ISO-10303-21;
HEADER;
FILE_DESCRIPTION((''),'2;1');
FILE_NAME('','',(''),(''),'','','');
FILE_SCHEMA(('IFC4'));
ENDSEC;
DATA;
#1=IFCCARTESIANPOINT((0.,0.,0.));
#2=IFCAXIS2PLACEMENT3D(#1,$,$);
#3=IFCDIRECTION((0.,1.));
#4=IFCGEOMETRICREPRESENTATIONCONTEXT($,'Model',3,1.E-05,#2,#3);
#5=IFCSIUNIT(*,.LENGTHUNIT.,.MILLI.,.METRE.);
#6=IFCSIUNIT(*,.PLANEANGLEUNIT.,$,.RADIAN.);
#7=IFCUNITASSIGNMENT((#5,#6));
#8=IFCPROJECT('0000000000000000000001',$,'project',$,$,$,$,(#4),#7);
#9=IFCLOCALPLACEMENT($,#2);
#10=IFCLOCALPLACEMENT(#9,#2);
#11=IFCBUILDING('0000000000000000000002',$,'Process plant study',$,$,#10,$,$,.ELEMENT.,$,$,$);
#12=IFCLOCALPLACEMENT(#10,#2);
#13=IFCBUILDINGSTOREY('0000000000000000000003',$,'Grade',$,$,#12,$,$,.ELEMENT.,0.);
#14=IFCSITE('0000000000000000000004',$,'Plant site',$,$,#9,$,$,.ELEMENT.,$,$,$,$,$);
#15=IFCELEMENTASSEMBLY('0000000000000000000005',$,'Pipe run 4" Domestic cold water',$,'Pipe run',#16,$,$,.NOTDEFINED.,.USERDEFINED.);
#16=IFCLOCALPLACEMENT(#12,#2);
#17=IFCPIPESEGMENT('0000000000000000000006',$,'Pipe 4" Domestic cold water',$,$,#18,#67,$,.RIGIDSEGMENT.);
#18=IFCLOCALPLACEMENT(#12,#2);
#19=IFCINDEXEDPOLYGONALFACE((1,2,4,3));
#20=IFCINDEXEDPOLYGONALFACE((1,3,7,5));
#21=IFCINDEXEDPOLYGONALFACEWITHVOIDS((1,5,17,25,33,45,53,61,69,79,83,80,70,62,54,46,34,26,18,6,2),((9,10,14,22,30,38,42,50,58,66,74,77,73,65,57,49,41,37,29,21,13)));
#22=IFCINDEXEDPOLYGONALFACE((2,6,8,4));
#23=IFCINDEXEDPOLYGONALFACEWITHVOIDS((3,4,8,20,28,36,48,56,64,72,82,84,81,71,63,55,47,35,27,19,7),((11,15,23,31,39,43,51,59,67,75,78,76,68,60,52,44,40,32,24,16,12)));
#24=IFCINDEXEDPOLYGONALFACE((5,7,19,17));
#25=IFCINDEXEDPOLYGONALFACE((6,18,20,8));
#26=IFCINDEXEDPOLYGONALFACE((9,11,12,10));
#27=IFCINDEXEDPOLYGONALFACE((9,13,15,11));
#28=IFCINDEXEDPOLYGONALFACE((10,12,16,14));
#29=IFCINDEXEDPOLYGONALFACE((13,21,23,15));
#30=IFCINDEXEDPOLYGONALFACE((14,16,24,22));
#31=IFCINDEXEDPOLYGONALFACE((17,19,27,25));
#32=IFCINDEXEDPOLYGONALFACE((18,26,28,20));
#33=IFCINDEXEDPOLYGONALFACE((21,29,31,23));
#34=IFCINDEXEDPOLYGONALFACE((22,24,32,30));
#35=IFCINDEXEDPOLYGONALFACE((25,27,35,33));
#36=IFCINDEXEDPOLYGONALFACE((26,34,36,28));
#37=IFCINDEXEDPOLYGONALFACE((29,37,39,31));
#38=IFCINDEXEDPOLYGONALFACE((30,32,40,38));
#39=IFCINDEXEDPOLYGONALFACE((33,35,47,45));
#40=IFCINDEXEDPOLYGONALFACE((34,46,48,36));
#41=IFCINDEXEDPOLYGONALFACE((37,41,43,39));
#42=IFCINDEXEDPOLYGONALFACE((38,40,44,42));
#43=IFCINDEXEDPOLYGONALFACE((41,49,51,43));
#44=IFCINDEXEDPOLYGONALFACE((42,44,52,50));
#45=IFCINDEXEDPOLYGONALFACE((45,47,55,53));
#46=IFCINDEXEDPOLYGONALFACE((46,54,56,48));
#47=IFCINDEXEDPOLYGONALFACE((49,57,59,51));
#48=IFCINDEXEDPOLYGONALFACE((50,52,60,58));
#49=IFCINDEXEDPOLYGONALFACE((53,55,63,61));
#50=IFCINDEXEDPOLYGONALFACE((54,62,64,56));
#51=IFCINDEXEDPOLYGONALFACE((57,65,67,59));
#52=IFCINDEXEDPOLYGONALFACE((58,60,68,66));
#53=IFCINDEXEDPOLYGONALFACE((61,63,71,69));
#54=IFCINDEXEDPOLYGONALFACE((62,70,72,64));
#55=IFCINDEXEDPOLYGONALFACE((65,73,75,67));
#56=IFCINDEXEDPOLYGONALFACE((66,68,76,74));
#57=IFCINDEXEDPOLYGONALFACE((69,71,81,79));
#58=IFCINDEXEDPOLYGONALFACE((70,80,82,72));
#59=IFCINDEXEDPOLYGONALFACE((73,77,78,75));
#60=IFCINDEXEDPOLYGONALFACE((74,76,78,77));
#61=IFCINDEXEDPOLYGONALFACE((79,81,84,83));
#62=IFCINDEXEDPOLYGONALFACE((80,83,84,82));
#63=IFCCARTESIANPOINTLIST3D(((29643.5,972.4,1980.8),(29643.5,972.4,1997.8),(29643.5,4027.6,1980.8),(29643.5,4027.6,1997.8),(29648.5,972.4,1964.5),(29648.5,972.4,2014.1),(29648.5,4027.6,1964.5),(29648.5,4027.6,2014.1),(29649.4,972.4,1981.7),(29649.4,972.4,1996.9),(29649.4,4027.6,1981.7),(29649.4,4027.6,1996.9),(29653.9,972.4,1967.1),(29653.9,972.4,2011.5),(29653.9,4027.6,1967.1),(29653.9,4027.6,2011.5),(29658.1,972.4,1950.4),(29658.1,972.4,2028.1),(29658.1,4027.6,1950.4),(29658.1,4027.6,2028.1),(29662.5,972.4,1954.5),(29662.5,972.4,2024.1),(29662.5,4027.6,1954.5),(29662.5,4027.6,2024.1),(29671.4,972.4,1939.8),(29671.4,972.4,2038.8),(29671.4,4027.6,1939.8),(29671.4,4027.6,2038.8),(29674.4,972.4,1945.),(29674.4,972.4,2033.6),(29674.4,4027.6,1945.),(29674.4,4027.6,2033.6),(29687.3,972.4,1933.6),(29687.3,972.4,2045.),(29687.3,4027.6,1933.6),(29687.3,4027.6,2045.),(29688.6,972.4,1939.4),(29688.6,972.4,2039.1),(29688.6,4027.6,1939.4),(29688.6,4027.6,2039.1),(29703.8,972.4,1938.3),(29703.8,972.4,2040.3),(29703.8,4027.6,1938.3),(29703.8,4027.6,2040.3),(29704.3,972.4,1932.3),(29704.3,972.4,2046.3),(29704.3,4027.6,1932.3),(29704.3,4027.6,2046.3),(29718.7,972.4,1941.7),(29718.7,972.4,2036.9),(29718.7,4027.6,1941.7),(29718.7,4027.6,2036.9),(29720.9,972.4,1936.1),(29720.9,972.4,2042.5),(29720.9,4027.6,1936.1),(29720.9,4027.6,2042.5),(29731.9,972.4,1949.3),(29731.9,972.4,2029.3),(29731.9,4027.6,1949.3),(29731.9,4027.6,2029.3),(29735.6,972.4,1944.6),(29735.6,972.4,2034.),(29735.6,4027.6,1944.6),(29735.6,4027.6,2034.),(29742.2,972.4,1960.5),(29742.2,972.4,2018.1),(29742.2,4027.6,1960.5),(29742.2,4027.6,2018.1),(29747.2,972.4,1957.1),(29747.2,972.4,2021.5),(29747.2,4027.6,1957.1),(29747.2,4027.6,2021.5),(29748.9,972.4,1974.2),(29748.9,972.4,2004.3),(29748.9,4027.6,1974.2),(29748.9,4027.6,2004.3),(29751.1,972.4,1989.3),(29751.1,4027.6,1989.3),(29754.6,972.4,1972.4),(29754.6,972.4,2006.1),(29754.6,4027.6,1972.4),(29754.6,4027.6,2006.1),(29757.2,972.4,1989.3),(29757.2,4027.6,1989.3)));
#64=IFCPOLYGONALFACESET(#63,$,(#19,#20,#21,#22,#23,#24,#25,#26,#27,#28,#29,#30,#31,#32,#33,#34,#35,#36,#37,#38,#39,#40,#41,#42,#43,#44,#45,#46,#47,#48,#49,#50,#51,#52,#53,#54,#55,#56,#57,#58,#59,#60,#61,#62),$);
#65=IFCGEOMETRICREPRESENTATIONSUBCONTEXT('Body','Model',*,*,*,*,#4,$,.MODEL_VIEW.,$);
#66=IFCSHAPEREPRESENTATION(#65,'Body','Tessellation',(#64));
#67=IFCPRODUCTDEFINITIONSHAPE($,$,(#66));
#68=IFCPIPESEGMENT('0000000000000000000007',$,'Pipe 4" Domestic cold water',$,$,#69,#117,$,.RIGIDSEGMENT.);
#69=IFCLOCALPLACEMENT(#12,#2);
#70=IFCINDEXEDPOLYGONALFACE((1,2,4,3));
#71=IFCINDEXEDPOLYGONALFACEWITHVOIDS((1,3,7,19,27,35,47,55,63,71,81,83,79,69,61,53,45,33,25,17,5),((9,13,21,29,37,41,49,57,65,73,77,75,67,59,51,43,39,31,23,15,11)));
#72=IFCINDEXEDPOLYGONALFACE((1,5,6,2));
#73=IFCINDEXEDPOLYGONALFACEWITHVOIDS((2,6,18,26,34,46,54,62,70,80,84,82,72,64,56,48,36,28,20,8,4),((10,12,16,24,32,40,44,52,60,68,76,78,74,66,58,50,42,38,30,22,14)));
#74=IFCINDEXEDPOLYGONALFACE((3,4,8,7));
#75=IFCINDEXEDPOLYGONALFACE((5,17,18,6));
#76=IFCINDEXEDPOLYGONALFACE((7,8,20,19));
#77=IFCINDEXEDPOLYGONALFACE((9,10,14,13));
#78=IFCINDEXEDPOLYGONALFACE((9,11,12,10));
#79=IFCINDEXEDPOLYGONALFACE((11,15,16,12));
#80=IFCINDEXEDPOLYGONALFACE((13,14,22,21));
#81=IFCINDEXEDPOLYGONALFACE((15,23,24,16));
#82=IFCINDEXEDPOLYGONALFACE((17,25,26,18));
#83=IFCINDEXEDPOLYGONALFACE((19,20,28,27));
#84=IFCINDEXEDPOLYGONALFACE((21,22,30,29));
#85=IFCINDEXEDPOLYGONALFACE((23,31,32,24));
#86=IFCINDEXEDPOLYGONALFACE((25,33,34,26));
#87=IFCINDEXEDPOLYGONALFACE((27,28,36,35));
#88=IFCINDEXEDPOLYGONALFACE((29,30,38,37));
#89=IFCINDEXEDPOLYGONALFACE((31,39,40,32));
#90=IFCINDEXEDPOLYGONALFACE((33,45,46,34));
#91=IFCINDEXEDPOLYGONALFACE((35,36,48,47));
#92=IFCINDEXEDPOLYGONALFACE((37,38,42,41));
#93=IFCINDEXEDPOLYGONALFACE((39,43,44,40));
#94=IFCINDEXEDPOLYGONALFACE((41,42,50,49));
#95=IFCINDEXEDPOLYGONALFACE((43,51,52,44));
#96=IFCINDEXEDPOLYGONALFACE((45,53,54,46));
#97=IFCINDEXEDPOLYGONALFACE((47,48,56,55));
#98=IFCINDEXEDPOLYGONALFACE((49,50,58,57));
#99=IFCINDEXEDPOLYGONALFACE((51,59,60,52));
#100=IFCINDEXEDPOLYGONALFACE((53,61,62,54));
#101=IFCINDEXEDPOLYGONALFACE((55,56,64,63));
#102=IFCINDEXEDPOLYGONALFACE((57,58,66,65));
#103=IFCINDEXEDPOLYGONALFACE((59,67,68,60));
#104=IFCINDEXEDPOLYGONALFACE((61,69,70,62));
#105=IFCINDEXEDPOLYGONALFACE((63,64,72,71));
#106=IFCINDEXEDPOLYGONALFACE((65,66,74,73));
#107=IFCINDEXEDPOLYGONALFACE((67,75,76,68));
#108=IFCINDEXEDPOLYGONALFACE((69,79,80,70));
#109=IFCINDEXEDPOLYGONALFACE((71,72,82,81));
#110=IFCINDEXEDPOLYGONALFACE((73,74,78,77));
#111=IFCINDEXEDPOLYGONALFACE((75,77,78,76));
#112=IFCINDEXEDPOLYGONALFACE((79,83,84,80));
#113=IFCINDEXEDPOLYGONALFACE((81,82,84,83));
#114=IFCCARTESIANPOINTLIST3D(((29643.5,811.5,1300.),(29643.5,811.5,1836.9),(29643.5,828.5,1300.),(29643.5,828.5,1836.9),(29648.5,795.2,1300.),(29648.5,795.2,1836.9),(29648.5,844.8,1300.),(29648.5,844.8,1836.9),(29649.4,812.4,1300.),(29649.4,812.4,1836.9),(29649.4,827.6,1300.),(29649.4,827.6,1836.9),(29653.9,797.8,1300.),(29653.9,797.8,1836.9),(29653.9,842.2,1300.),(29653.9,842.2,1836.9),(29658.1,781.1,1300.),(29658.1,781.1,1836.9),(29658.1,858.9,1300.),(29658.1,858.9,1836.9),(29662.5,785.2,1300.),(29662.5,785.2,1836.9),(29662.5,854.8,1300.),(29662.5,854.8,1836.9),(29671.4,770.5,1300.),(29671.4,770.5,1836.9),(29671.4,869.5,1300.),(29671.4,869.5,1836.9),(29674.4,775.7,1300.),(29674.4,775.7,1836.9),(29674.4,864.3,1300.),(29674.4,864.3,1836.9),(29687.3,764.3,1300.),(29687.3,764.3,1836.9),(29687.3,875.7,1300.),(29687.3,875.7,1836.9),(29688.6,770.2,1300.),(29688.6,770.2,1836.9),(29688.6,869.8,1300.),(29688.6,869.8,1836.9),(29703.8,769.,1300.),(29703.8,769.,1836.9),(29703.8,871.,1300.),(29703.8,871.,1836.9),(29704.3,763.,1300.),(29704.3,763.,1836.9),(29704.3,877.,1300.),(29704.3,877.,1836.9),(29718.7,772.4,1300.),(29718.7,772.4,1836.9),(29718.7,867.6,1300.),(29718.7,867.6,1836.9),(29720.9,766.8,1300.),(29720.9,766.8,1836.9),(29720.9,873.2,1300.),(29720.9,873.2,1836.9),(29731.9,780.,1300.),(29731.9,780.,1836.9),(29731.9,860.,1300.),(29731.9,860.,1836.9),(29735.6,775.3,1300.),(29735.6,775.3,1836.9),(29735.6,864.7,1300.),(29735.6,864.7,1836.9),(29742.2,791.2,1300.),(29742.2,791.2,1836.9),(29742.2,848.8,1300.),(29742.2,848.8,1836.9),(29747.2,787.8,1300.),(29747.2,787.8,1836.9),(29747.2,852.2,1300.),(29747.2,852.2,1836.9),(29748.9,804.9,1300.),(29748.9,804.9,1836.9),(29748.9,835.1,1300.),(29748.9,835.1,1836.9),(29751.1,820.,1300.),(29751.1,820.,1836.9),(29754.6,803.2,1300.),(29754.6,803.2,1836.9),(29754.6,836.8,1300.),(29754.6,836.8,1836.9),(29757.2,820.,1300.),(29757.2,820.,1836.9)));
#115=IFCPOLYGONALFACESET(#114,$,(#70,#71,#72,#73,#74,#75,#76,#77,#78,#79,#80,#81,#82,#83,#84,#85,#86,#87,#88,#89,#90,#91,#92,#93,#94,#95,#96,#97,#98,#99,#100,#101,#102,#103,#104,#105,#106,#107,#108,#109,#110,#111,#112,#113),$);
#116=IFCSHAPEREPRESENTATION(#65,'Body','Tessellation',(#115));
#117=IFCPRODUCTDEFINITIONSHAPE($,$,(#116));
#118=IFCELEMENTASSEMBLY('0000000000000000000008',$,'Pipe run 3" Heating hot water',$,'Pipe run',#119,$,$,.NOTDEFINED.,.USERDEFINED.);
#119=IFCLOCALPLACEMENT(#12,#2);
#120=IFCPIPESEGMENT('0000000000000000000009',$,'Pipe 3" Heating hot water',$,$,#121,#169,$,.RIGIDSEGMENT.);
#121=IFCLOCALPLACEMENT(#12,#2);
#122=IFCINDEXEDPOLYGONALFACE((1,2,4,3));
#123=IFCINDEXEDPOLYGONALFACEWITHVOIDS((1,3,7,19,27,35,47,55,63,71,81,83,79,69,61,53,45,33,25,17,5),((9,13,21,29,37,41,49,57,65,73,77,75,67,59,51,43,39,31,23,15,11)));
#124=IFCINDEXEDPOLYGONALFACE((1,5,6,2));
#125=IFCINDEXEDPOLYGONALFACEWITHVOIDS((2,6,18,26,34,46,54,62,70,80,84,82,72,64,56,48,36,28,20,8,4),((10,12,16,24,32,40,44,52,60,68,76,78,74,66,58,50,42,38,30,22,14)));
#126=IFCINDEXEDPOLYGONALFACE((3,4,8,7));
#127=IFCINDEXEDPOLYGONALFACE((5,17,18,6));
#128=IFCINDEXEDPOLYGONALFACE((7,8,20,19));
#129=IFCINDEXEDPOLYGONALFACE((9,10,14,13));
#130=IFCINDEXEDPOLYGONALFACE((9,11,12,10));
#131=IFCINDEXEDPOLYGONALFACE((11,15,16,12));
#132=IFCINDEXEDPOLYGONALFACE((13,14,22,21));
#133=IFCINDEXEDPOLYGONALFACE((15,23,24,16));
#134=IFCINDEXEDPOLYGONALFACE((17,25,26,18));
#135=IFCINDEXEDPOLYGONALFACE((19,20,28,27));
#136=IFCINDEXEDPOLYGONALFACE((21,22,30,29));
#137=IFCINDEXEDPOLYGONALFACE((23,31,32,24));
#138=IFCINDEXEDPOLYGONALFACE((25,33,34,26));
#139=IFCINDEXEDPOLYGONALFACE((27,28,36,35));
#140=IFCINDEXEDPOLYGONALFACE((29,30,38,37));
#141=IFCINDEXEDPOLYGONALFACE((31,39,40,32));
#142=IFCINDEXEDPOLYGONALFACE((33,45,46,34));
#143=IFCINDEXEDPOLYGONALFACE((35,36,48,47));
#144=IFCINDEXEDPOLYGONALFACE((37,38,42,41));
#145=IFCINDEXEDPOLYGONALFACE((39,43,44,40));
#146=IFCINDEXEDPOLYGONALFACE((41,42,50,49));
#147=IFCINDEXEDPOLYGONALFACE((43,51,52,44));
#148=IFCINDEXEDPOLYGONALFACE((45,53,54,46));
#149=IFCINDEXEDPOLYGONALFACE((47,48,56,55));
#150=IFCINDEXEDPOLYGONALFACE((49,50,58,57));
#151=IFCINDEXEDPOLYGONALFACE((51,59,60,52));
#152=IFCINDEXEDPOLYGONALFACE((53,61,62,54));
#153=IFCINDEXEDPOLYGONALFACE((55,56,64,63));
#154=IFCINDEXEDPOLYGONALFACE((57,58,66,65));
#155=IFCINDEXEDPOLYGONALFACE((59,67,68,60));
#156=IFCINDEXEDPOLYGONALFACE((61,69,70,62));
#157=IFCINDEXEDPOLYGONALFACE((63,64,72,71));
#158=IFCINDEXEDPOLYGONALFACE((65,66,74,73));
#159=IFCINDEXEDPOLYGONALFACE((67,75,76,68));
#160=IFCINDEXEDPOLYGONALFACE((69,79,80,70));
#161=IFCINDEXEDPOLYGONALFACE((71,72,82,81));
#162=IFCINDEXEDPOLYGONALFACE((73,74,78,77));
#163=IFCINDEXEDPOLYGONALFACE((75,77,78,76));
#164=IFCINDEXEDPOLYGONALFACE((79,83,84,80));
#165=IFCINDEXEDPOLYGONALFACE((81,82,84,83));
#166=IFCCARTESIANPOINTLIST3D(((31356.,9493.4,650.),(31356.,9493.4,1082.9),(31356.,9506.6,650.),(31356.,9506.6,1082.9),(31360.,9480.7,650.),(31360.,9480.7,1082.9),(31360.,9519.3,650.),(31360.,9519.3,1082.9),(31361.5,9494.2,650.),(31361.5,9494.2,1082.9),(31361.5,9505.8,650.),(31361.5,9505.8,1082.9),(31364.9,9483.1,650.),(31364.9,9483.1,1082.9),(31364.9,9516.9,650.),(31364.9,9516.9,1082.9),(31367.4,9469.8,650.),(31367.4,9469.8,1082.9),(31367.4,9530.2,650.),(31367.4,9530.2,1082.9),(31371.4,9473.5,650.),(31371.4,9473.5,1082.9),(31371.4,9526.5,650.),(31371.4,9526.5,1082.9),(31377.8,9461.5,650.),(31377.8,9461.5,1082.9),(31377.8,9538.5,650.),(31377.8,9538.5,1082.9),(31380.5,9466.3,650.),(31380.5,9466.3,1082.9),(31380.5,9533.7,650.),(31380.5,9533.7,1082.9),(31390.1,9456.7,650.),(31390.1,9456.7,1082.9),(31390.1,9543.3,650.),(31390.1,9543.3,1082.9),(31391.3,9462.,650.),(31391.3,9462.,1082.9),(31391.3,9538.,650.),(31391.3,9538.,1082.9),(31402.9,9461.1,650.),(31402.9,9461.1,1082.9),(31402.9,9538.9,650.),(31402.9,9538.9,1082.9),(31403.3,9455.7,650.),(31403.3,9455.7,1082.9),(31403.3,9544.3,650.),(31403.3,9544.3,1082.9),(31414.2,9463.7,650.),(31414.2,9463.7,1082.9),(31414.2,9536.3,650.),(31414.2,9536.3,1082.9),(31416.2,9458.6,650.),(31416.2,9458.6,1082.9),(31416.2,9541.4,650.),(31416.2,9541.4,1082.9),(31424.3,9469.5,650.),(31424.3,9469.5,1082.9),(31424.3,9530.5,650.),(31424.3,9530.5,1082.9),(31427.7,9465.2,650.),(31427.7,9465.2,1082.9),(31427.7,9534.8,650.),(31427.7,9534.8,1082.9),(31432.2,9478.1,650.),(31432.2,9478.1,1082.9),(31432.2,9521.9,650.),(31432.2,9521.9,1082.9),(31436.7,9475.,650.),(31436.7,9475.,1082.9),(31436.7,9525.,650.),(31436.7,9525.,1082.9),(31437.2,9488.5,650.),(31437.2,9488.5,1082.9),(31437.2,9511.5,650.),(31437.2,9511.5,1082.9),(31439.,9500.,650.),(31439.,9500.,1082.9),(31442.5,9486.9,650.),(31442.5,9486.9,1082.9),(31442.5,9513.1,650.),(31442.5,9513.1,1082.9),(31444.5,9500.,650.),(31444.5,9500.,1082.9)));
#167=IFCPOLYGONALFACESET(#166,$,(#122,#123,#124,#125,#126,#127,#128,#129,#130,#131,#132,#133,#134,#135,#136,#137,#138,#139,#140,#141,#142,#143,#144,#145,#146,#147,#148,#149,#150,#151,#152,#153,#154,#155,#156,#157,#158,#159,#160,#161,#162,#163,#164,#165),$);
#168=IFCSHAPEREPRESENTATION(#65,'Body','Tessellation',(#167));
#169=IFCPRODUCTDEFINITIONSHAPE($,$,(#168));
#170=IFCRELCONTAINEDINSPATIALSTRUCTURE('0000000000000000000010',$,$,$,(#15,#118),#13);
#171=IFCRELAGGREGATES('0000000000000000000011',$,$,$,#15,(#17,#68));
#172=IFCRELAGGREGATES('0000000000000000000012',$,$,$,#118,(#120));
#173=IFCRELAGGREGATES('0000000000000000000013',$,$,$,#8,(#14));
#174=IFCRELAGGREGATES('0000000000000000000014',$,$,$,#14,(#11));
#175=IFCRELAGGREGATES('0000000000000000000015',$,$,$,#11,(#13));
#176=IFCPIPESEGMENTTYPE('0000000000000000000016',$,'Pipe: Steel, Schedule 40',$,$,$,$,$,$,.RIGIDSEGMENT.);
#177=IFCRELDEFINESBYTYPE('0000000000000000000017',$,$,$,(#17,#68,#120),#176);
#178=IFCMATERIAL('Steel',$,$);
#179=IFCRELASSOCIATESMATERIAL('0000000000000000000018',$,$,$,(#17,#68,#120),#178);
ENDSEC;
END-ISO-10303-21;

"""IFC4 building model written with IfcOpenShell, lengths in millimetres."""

from ifc_helpers import new_model, si_unit, direction, frame, origin, origin_with_axes, origin_2d, place, context, subcontext, project, spatial, hollow_circle, extrude, material, type_object, element, aggregate, save


model = new_model("IFC4")

# Units and contexts
model_context = context("Model", 3, precision=1e-05, world=origin(), true_north=direction((0.0, 1.0)))
body_context = subcontext(model_context, "Body", "Model", "MODEL_VIEW")
ifc_project = project(units=[si_unit("LENGTHUNIT", "METRE", prefix="MILLI"), si_unit("PLANEANGLEUNIT", "RADIAN")], contexts=[model_context])

# Site, building, storey
site_placement = place(None, origin())
site = spatial("IfcSite", under=ifc_project, at=site_placement, Name="Plant site", CompositionType="ELEMENT")
building_placement = place(site_placement, origin())
building = spatial("IfcBuilding", under=site, at=building_placement, Name="Process plant study", CompositionType="ELEMENT")
storey_placement = place(building_placement, origin())
storey = spatial("IfcBuildingStorey", under=building, at=storey_placement, Name="Grade", CompositionType="ELEMENT", Elevation=0.0)

# Shared definitions
ifc_material = material(Name="Steel")
pipe_segment_type = type_object("IfcPipeSegmentType", Name="Pipe: Steel, Schedule 40", PredefinedType="RIGIDSEGMENT")

# Element assemblies, pipe segments
assembly_1_placement = place(storey_placement, origin_with_axes())
assembly_1 = element("IfcElementAssembly", 1, at=assembly_1_placement, inside=storey, Name="Pipe run 4\" Domestic cold water", ObjectType="Pipe run", AssemblyPlace="NOTDEFINED", PredefinedType="USERDEFINED")
pipe_segment_1_placement = place(storey_placement, origin_with_axes())
pipe_segment_1 = element("IfcPipeSegment", 2, at=pipe_segment_1_placement, type_object=pipe_segment_type, material=ifc_material, Name="Pipe 4\" Domestic cold water", PredefinedType="RIGIDSEGMENT", context=body_context, shape_type="SweptSolid", body=[
    extrude(hollow_circle(Radius=57.1, WallThickness=6.0, at=origin_2d()), frame((29700.0, 4027.6, 1989.3), z_axis=(0.0, -1.0, 0.0), x_axis=(1.0, 0.0, 0.0)), (0.0, 0.0, 1.0), 3055.2),
])
pipe_segment_2_placement = place(storey_placement, origin_with_axes())
pipe_segment_2 = element("IfcPipeSegment", 3, at=pipe_segment_2_placement, type_object=pipe_segment_type, material=ifc_material, Name="Pipe 4\" Domestic cold water", PredefinedType="RIGIDSEGMENT", context=body_context, shape_type="SweptSolid", body=[
    extrude(hollow_circle(Radius=57.1, WallThickness=6.0, at=origin_2d()), frame((29700.0, 820.0, 1836.9), z_axis=(0.0, 0.0, -1.0), x_axis=(1.0, 0.0, 0.0)), (0.0, 0.0, 1.0), 536.9),
])
assembly_2_placement = place(storey_placement, origin_with_axes())
assembly_2 = element("IfcElementAssembly", 4, at=assembly_2_placement, inside=storey, Name="Pipe run 3\" Heating hot water", ObjectType="Pipe run", AssemblyPlace="NOTDEFINED", PredefinedType="USERDEFINED")
pipe_segment_3_placement = place(storey_placement, origin_with_axes())
pipe_segment_3 = element("IfcPipeSegment", 5, at=pipe_segment_3_placement, type_object=pipe_segment_type, material=ifc_material, Name="Pipe 3\" Heating hot water", PredefinedType="RIGIDSEGMENT", context=body_context, shape_type="SweptSolid", body=[
    extrude(hollow_circle(Radius=44.5, WallThickness=5.5, at=origin_2d()), frame((31400.0, 9500.0, 650.0), z_axis=(0.0, 0.0, 1.0), x_axis=(1.0, 0.0, 0.0)), (0.0, 0.0, 1.0), 432.9),
])

aggregate(assembly_1, [pipe_segment_1, pipe_segment_2])
aggregate(assembly_2, [pipe_segment_3])

save(model, "model.ifc")
